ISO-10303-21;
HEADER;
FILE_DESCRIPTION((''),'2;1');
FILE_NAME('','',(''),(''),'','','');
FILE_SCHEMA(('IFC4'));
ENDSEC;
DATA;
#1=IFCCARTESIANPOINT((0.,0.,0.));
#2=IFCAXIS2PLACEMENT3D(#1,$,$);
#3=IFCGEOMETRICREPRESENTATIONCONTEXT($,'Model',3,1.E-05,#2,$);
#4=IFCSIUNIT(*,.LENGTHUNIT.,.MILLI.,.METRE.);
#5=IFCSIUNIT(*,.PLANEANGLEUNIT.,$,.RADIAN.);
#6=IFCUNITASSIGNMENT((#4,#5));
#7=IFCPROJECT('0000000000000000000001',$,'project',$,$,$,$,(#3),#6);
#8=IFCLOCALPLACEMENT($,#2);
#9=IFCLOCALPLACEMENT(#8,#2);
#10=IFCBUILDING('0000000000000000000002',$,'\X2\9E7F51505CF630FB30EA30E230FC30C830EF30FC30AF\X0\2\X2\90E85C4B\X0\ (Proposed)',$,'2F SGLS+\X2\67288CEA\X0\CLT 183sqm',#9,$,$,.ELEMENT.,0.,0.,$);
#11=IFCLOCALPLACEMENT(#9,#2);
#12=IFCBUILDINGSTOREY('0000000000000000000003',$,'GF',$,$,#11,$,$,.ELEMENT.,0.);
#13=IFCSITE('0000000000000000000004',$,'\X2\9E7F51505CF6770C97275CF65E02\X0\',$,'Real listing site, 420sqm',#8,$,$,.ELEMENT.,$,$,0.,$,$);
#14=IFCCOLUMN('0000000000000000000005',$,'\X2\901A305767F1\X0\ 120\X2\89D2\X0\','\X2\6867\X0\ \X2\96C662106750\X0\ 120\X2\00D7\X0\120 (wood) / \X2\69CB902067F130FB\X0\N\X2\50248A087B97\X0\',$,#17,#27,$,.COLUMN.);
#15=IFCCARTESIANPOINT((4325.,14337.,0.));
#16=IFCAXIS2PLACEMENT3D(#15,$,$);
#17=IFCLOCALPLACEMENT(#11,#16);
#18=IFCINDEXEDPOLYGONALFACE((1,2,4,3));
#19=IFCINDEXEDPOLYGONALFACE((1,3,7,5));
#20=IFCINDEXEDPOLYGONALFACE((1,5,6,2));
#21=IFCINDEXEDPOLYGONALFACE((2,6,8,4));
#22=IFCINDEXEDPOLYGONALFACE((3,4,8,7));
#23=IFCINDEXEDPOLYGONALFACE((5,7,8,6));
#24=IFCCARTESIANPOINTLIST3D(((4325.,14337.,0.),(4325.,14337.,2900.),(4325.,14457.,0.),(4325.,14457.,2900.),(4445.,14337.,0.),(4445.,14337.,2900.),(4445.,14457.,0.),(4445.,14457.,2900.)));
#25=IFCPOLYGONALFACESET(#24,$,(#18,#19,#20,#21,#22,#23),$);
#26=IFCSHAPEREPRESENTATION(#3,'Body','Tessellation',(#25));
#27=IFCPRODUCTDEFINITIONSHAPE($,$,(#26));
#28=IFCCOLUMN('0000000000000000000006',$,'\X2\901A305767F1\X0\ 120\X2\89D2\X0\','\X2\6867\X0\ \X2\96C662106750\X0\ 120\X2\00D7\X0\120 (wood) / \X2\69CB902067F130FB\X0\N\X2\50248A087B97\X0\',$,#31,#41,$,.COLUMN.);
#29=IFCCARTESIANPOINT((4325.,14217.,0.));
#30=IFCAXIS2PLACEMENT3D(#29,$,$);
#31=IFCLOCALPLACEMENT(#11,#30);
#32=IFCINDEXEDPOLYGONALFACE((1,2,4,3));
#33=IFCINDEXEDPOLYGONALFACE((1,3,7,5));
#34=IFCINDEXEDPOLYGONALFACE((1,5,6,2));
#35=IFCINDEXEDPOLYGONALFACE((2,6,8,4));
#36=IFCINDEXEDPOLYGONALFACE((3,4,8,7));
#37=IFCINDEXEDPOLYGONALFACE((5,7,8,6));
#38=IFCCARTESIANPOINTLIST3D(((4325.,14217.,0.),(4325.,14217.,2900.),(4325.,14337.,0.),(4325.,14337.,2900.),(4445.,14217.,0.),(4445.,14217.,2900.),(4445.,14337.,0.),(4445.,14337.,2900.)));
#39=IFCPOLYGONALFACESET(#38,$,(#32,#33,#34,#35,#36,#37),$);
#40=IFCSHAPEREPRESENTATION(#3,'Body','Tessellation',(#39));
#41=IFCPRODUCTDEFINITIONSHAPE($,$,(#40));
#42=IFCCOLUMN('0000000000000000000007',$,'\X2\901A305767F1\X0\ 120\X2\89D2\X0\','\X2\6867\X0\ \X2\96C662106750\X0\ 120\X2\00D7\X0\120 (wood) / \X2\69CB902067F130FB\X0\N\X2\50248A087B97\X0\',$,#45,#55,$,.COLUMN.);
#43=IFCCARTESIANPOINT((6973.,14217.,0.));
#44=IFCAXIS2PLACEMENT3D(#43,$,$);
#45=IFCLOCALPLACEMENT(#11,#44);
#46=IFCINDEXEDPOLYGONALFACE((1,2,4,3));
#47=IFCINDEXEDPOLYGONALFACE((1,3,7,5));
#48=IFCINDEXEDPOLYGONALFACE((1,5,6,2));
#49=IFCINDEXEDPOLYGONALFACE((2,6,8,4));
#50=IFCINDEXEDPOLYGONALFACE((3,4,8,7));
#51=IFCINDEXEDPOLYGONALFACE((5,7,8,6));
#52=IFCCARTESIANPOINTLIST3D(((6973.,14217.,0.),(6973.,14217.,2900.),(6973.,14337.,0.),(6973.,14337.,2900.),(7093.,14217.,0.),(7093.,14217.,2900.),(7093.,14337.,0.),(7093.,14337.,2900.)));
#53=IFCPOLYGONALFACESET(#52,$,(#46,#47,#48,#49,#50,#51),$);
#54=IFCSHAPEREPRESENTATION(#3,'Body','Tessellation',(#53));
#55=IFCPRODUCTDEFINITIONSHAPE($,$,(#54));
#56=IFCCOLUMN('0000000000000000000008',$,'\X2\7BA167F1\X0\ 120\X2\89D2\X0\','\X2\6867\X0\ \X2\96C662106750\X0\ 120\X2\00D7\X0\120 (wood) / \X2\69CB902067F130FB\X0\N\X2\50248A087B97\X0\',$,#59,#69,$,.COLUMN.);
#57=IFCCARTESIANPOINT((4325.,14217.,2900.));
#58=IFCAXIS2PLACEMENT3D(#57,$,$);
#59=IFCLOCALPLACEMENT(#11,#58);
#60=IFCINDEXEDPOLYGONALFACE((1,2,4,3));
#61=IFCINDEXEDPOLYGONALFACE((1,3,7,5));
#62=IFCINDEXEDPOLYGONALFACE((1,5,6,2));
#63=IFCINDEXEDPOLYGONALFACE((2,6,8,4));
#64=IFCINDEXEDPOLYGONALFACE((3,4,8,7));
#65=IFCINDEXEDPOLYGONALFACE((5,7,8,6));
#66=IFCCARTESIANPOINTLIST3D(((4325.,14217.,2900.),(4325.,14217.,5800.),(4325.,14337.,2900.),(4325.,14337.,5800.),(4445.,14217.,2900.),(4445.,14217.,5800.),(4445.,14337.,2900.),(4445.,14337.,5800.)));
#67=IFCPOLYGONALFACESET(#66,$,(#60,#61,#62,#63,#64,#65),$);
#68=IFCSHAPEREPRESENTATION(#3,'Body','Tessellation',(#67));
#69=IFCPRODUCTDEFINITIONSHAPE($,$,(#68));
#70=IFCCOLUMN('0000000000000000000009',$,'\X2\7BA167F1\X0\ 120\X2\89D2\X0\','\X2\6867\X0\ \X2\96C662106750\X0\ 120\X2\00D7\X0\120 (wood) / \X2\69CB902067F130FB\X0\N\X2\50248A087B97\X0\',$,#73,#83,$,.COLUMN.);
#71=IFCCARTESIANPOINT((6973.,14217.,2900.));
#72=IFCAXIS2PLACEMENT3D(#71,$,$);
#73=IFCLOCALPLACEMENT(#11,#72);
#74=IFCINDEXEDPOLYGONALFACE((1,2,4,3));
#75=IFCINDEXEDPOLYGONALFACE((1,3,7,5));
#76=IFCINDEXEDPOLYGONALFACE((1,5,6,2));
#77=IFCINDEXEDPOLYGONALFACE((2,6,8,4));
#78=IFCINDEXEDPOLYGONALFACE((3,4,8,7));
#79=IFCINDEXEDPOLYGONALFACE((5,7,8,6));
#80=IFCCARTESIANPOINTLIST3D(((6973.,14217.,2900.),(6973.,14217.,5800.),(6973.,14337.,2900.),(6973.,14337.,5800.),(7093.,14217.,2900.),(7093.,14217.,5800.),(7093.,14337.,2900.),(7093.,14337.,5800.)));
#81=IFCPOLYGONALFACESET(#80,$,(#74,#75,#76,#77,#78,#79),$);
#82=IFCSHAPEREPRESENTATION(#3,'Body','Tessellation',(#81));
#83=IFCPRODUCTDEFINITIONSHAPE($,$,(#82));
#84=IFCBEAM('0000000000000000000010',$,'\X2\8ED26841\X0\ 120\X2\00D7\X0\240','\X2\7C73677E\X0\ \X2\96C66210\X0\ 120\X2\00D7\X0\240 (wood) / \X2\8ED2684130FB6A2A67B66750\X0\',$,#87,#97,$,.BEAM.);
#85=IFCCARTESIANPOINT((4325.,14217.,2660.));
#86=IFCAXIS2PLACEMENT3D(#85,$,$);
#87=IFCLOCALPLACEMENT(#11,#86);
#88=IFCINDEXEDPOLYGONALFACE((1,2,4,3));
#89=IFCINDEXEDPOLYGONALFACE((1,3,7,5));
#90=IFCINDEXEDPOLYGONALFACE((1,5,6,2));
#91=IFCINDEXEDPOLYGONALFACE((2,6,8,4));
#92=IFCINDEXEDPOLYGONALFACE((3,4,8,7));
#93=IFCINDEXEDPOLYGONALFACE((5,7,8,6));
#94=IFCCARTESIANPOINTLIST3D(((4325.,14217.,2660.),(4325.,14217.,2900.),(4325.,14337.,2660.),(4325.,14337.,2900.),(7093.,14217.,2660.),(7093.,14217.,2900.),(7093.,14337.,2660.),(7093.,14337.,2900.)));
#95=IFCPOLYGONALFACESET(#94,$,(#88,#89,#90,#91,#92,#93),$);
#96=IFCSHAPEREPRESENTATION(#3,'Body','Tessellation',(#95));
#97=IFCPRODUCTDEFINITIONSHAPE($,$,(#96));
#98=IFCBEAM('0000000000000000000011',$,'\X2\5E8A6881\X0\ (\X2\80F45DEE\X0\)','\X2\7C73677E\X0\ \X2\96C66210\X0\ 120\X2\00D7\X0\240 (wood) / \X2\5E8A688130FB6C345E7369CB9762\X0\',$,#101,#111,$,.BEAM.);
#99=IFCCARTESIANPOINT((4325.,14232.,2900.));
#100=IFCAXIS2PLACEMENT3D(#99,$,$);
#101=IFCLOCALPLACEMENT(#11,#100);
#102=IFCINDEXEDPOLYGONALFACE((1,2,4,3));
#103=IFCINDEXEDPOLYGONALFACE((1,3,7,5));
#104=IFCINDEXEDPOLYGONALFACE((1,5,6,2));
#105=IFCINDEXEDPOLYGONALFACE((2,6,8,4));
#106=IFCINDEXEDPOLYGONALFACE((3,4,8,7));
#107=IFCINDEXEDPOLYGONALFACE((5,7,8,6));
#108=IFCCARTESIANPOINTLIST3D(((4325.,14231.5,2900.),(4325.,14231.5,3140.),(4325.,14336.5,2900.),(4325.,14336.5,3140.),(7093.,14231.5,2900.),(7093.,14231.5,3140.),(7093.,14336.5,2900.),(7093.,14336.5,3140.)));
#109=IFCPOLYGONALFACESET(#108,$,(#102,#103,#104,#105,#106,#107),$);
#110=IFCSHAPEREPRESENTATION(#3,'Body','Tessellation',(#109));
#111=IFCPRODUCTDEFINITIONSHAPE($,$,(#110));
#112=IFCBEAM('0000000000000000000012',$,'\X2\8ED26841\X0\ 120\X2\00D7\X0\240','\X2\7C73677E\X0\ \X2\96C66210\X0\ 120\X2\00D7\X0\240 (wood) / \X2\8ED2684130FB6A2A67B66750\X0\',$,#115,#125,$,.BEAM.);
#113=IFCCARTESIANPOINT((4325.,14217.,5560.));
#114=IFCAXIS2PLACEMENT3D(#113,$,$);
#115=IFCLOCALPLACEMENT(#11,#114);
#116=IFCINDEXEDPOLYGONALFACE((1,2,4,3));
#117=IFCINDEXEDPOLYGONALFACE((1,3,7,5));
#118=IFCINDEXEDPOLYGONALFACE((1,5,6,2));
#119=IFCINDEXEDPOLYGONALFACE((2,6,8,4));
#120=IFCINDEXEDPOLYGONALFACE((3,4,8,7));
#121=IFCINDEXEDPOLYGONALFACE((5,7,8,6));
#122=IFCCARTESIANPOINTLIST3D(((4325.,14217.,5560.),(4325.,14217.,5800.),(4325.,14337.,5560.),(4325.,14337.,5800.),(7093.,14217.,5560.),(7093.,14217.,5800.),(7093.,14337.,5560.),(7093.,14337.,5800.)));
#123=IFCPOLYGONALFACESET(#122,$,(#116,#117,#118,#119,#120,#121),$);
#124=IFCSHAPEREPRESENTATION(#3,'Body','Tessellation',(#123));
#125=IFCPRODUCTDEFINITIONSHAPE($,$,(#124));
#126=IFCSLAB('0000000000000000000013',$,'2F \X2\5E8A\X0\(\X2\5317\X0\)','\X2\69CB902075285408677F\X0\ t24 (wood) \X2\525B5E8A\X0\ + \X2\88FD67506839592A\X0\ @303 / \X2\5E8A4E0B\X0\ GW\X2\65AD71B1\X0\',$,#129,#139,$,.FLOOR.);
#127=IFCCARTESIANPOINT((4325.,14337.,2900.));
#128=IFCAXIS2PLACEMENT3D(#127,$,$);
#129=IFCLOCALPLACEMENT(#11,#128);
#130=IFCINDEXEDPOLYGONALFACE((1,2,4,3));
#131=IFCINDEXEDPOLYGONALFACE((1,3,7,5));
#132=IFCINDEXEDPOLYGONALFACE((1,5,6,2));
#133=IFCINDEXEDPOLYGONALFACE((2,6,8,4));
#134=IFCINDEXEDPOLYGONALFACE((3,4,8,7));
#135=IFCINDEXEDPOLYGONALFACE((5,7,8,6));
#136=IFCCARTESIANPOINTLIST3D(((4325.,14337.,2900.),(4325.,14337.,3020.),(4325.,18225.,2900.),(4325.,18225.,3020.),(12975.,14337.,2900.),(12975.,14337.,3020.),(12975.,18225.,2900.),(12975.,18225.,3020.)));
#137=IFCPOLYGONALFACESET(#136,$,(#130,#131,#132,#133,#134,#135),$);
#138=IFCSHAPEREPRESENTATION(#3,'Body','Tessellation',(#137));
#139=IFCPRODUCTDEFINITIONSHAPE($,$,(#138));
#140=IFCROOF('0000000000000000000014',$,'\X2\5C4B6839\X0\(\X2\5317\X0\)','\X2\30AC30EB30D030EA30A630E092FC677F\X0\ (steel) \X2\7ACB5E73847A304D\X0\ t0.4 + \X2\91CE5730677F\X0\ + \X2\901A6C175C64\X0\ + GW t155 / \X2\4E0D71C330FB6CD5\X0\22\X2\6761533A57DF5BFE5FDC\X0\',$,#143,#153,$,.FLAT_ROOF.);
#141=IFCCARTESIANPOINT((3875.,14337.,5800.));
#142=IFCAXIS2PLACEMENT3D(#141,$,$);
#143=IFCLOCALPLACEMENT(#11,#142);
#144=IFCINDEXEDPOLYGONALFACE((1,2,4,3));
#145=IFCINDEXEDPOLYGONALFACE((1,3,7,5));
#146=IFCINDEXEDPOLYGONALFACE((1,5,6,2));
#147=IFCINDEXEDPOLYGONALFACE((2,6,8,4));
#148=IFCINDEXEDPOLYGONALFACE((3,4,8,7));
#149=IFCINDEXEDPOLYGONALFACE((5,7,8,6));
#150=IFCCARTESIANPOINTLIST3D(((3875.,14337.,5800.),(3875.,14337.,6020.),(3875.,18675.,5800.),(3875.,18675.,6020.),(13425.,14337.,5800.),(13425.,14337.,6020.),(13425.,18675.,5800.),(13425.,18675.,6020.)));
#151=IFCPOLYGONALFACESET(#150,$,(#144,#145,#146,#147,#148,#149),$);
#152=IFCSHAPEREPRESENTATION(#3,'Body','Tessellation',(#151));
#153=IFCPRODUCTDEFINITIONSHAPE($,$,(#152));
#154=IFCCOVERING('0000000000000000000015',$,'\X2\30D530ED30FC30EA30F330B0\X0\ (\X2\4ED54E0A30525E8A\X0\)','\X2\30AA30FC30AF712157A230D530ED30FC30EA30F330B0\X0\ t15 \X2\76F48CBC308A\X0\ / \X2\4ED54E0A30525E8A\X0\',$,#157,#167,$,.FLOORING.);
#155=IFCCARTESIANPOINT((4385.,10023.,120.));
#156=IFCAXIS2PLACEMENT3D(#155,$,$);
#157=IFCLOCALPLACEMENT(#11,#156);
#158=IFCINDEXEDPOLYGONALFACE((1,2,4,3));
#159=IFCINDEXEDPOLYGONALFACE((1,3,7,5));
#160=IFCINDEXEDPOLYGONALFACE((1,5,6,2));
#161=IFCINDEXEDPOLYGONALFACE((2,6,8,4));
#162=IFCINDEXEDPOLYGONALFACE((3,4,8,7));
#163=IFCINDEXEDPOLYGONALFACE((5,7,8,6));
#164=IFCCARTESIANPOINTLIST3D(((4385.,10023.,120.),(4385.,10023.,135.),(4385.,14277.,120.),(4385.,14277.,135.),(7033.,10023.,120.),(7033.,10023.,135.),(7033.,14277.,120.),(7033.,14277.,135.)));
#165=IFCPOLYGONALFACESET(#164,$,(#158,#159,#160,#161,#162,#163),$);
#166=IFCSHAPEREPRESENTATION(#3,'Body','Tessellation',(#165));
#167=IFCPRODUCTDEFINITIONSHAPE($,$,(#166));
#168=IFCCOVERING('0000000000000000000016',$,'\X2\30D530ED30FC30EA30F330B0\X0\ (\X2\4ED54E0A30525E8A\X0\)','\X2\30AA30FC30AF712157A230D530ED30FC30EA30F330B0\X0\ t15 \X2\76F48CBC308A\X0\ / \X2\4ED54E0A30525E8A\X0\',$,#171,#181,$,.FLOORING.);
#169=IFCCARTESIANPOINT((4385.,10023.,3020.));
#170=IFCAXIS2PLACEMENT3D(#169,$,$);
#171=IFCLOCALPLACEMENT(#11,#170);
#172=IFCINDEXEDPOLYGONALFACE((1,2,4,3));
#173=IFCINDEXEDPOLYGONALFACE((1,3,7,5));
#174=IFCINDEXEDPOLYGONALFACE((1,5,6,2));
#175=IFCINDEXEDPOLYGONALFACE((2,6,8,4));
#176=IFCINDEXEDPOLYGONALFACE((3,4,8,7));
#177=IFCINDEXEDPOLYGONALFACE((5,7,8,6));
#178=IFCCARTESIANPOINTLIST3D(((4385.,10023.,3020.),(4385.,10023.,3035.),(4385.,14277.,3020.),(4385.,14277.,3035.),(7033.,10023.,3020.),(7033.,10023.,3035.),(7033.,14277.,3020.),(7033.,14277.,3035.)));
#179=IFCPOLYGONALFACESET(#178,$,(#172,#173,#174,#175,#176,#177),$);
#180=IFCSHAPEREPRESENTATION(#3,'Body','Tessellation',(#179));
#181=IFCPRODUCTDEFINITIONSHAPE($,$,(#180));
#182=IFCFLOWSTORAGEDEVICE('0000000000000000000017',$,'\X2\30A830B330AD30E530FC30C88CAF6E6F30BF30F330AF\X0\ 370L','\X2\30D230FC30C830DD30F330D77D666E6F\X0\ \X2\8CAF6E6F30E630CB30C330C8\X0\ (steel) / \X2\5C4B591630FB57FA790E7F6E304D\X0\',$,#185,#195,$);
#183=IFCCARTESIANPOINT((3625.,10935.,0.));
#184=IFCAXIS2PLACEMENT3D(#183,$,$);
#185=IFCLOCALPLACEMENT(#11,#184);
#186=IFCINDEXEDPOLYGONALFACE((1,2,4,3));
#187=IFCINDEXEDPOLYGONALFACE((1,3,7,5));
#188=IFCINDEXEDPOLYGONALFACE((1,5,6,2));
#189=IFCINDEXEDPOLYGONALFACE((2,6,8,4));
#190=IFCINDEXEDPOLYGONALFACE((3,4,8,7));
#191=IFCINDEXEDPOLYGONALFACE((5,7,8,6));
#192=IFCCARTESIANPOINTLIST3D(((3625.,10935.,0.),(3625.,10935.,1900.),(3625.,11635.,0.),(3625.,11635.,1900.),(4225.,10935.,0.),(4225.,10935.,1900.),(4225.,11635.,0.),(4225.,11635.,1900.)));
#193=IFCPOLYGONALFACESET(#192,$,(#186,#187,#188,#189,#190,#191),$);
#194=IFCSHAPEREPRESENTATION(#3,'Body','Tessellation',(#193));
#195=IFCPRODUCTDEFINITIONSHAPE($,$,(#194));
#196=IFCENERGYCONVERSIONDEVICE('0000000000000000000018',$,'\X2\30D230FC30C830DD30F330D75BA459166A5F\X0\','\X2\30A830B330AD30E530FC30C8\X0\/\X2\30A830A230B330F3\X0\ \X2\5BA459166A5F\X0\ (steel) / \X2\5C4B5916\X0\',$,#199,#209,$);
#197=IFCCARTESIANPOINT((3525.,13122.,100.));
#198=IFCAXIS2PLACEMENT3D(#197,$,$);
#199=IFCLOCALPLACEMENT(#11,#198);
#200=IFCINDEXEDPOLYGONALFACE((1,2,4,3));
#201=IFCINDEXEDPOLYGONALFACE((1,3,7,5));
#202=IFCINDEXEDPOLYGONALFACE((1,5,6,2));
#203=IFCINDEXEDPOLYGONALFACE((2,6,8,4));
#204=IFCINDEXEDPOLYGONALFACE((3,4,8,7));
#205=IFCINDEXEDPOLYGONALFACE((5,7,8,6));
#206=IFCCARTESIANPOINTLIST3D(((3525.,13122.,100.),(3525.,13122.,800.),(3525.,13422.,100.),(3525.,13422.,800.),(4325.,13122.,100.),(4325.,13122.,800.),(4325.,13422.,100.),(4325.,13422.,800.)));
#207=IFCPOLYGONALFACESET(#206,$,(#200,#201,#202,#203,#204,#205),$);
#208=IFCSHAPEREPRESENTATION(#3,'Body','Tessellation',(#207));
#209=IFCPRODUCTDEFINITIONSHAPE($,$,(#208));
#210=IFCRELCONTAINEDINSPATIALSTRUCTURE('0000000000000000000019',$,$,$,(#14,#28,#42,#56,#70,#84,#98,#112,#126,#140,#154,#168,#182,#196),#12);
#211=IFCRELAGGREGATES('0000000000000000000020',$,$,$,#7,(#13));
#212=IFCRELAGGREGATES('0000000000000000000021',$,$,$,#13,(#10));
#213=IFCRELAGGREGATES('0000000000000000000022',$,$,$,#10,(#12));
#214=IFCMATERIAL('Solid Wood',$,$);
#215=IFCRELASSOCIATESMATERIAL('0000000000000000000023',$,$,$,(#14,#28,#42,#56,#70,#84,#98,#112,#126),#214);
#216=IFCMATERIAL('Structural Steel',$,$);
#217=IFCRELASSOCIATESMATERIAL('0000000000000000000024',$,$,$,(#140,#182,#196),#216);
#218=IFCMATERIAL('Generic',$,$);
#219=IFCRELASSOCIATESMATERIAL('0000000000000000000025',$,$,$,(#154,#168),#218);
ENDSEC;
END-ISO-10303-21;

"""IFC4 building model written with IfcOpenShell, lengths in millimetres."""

from ifc_helpers import new_model, si_unit, frame, frame_2d, origin, place, context, project, spatial, rectangle, extrude, material, element, save


model = new_model("IFC4")

# Units and contexts
model_context = context("Model", 3, precision=1e-05, world=origin())
ifc_project = project(units=[si_unit("LENGTHUNIT", "METRE", prefix="MILLI"), si_unit("PLANEANGLEUNIT", "RADIAN")], contexts=[model_context])

# Site, building, storey
site_placement = place(None, origin())
site = spatial("IfcSite", under=ifc_project, at=site_placement, Name="鹿児島県霧島市", ObjectType="Real listing site, 420sqm", CompositionType="ELEMENT", RefElevation=0.0)
building_placement = place(site_placement, origin())
building = spatial("IfcBuilding", under=site, at=building_placement, Name="鹿児島・リモートワーク2部屋 (Proposed)", ObjectType="2F SGLS+木質CLT 183sqm", CompositionType="ELEMENT", ElevationOfRefHeight=0.0, ElevationOfTerrain=0.0)
storey_placement = place(building_placement, origin())
storey = spatial("IfcBuildingStorey", under=building, at=storey_placement, Name="GF", CompositionType="ELEMENT", Elevation=0.0)

# Columns
ifc_material_1 = material(Name="Solid Wood")
column_1_placement = place(storey_placement, frame((4325.0, 14337.0, 0.0)))
element("IfcColumn", 1, at=column_1_placement, inside=storey, material=ifc_material_1, Name="通し柱 120角", Description="桧 集成材 120×120 (wood) / 構造柱・N値計算", PredefinedType="COLUMN", context=model_context, shape_type="SweptSolid", body=[
    extrude(rectangle(XDim=120.0, YDim=120.0, at=frame_2d((60.0, 60.0))), frame((4325.0, 14337.0, 0.0)), (0.0, 0.0, 1.0), 2900.0),
])
column_2_placement = place(storey_placement, frame((4325.0, 14217.0, 0.0)))
element("IfcColumn", 2, at=column_2_placement, inside=storey, material=ifc_material_1, Name="通し柱 120角", Description="桧 集成材 120×120 (wood) / 構造柱・N値計算", PredefinedType="COLUMN", context=model_context, shape_type="SweptSolid", body=[
    extrude(rectangle(XDim=120.0, YDim=120.0, at=frame_2d((60.0, 60.0))), frame((4325.0, 14217.0, 0.0)), (0.0, 0.0, 1.0), 2900.0),
])
column_3_placement = place(storey_placement, frame((6973.0, 14217.0, 0.0)))
element("IfcColumn", 3, at=column_3_placement, inside=storey, material=ifc_material_1, Name="通し柱 120角", Description="桧 集成材 120×120 (wood) / 構造柱・N値計算", PredefinedType="COLUMN", context=model_context, shape_type="SweptSolid", body=[
    extrude(rectangle(XDim=120.0, YDim=120.0, at=frame_2d((60.0, 60.0))), frame((6973.0, 14217.0, 0.0)), (0.0, 0.0, 1.0), 2900.0),
])
column_4_placement = place(storey_placement, frame((4325.0, 14217.0, 2900.0)))
element("IfcColumn", 4, at=column_4_placement, inside=storey, material=ifc_material_1, Name="管柱 120角", Description="桧 集成材 120×120 (wood) / 構造柱・N値計算", PredefinedType="COLUMN", context=model_context, shape_type="SweptSolid", body=[
    extrude(rectangle(XDim=120.0, YDim=120.0, at=frame_2d((60.0, 60.0))), frame((4325.0, 14217.0, 2900.0)), (0.0, 0.0, 1.0), 2900.0),
])
column_5_placement = place(storey_placement, frame((6973.0, 14217.0, 2900.0)))
element("IfcColumn", 5, at=column_5_placement, inside=storey, material=ifc_material_1, Name="管柱 120角", Description="桧 集成材 120×120 (wood) / 構造柱・N値計算", PredefinedType="COLUMN", context=model_context, shape_type="SweptSolid", body=[
    extrude(rectangle(XDim=120.0, YDim=120.0, at=frame_2d((60.0, 60.0))), frame((6973.0, 14217.0, 2900.0)), (0.0, 0.0, 1.0), 2900.0),
])

# Beams
beam_1_placement = place(storey_placement, frame((4325.0, 14217.0, 2660.0)))
element("IfcBeam", 6, at=beam_1_placement, inside=storey, material=ifc_material_1, Name="軒桁 120×240", Description="米松 集成 120×240 (wood) / 軒桁・横架材", PredefinedType="BEAM", context=model_context, shape_type="SweptSolid", body=[
    extrude(rectangle(XDim=2768.0, YDim=120.0, at=frame_2d((1384.0, 60.0))), frame((4325.0, 14217.0, 2660.0)), (0.0, 0.0, 1.0), 240.0),
])
beam_2_placement = place(storey_placement, frame((4325.0, 14232.0, 2900.0)))
element("IfcBeam", 7, at=beam_2_placement, inside=storey, material=ifc_material_1, Name="床梁 (胴差)", Description="米松 集成 120×240 (wood) / 床梁・水平構面", PredefinedType="BEAM", context=model_context, shape_type="SweptSolid", body=[
    extrude(rectangle(XDim=2768.0, YDim=105.0, at=frame_2d((1384.0, 52.0))), frame((4325.0, 14232.0, 2900.0)), (0.0, 0.0, 1.0), 240.0),
])
beam_3_placement = place(storey_placement, frame((4325.0, 14217.0, 5560.0)))
element("IfcBeam", 8, at=beam_3_placement, inside=storey, material=ifc_material_1, Name="軒桁 120×240", Description="米松 集成 120×240 (wood) / 軒桁・横架材", PredefinedType="BEAM", context=model_context, shape_type="SweptSolid", body=[
    extrude(rectangle(XDim=2768.0, YDim=120.0, at=frame_2d((1384.0, 60.0))), frame((4325.0, 14217.0, 5560.0)), (0.0, 0.0, 1.0), 240.0),
])

# Slab
slab_1_placement = place(storey_placement, frame((4325.0, 14337.0, 2900.0)))
element("IfcSlab", 9, at=slab_1_placement, inside=storey, material=ifc_material_1, Name="2F 床(北)", Description="構造用合板 t24 (wood) 剛床 + 製材根太 @303 / 床下 GW断熱", PredefinedType="FLOOR", context=model_context, shape_type="SweptSolid", body=[
    extrude(rectangle(XDim=8650.0, YDim=3888.0, at=frame_2d((4325.0, 1944.0))), frame((4325.0, 14337.0, 2900.0)), (0.0, 0.0, 1.0), 120.0),
])

# Roof
ifc_material_2 = material(Name="Structural Steel")
for number, where, name in (
    (10, (3875.0, 14337.0, 5800.0), "屋根(北)"),
):
    element("IfcRoof", number, at=place(storey_placement, frame(where)), inside=storey, material=ifc_material_2, Name=name, Description="ガルバリウム鋼板 (steel) 立平葺き t0.4 + 野地板 + 通気層 + GW t155 / 不燃・法22条区域対応", PredefinedType="FLAT_ROOF", context=model_context, shape_type="SweptSolid", body=[
        extrude(rectangle(XDim=9550.0, YDim=4338.0, at=frame_2d((4775.0, 2169.0))), frame((3875.0, 14337.0, 5800.0)), (0.0, 0.0, 1.0), 220.0),
    ])

# Coverings
ifc_material_3 = material(Name="Generic")
covering_1_placement = place(storey_placement, frame((4385.0, 10023.0, 120.0)))
element("IfcCovering", 11, at=covering_1_placement, inside=storey, material=ifc_material_3, Name="フローリング (仕上げ床)", Description="オーク無垢フローリング t15 直貼り / 仕上げ床", PredefinedType="FLOORING", context=model_context, shape_type="SweptSolid", body=[
    extrude(rectangle(XDim=2648.0, YDim=4254.0, at=frame_2d((1324.0, 2127.0))), frame((4385.0, 10023.0, 120.0)), (0.0, 0.0, 1.0), 15.0),
])
covering_2_placement = place(storey_placement, frame((4385.0, 10023.0, 3020.0)))
element("IfcCovering", 12, at=covering_2_placement, inside=storey, material=ifc_material_3, Name="フローリング (仕上げ床)", Description="オーク無垢フローリング t15 直貼り / 仕上げ床", PredefinedType="FLOORING", context=model_context, shape_type="SweptSolid", body=[
    extrude(rectangle(XDim=2648.0, YDim=4254.0, at=frame_2d((1324.0, 2127.0))), frame((4385.0, 10023.0, 3020.0)), (0.0, 0.0, 1.0), 15.0),
])

# Flow storage device
flow_storage_device_placement = place(storey_placement, frame((3625.0, 10935.0, 0.0)))
element("IfcFlowStorageDevice", 13, at=flow_storage_device_placement, inside=storey, material=ifc_material_2, Name="エコキュート貯湯タンク 370L", Description="ヒートポンプ給湯 貯湯ユニット (steel) / 屋外・基礎置き", context=model_context, shape_type="SweptSolid", body=[
    extrude(rectangle(XDim=600.0, YDim=700.0, at=frame_2d((300.0, 350.0))), frame((3625.0, 10935.0, 0.0)), (0.0, 0.0, 1.0), 1900.0),
])

# Energy conversion device
energy_conversion_device_placement = place(storey_placement, frame((3525.0, 13122.0, 100.0)))
element("IfcEnergyConversionDevice", 14, at=energy_conversion_device_placement, inside=storey, material=ifc_material_2, Name="ヒートポンプ室外機", Description="エコキュート/エアコン 室外機 (steel) / 屋外", context=model_context, shape_type="SweptSolid", body=[
    extrude(rectangle(XDim=800.0, YDim=300.0, at=frame_2d((400.0, 150.0))), frame((3525.0, 13122.0, 100.0)), (0.0, 0.0, 1.0), 700.0),
])

save(model, "model.ifc")
